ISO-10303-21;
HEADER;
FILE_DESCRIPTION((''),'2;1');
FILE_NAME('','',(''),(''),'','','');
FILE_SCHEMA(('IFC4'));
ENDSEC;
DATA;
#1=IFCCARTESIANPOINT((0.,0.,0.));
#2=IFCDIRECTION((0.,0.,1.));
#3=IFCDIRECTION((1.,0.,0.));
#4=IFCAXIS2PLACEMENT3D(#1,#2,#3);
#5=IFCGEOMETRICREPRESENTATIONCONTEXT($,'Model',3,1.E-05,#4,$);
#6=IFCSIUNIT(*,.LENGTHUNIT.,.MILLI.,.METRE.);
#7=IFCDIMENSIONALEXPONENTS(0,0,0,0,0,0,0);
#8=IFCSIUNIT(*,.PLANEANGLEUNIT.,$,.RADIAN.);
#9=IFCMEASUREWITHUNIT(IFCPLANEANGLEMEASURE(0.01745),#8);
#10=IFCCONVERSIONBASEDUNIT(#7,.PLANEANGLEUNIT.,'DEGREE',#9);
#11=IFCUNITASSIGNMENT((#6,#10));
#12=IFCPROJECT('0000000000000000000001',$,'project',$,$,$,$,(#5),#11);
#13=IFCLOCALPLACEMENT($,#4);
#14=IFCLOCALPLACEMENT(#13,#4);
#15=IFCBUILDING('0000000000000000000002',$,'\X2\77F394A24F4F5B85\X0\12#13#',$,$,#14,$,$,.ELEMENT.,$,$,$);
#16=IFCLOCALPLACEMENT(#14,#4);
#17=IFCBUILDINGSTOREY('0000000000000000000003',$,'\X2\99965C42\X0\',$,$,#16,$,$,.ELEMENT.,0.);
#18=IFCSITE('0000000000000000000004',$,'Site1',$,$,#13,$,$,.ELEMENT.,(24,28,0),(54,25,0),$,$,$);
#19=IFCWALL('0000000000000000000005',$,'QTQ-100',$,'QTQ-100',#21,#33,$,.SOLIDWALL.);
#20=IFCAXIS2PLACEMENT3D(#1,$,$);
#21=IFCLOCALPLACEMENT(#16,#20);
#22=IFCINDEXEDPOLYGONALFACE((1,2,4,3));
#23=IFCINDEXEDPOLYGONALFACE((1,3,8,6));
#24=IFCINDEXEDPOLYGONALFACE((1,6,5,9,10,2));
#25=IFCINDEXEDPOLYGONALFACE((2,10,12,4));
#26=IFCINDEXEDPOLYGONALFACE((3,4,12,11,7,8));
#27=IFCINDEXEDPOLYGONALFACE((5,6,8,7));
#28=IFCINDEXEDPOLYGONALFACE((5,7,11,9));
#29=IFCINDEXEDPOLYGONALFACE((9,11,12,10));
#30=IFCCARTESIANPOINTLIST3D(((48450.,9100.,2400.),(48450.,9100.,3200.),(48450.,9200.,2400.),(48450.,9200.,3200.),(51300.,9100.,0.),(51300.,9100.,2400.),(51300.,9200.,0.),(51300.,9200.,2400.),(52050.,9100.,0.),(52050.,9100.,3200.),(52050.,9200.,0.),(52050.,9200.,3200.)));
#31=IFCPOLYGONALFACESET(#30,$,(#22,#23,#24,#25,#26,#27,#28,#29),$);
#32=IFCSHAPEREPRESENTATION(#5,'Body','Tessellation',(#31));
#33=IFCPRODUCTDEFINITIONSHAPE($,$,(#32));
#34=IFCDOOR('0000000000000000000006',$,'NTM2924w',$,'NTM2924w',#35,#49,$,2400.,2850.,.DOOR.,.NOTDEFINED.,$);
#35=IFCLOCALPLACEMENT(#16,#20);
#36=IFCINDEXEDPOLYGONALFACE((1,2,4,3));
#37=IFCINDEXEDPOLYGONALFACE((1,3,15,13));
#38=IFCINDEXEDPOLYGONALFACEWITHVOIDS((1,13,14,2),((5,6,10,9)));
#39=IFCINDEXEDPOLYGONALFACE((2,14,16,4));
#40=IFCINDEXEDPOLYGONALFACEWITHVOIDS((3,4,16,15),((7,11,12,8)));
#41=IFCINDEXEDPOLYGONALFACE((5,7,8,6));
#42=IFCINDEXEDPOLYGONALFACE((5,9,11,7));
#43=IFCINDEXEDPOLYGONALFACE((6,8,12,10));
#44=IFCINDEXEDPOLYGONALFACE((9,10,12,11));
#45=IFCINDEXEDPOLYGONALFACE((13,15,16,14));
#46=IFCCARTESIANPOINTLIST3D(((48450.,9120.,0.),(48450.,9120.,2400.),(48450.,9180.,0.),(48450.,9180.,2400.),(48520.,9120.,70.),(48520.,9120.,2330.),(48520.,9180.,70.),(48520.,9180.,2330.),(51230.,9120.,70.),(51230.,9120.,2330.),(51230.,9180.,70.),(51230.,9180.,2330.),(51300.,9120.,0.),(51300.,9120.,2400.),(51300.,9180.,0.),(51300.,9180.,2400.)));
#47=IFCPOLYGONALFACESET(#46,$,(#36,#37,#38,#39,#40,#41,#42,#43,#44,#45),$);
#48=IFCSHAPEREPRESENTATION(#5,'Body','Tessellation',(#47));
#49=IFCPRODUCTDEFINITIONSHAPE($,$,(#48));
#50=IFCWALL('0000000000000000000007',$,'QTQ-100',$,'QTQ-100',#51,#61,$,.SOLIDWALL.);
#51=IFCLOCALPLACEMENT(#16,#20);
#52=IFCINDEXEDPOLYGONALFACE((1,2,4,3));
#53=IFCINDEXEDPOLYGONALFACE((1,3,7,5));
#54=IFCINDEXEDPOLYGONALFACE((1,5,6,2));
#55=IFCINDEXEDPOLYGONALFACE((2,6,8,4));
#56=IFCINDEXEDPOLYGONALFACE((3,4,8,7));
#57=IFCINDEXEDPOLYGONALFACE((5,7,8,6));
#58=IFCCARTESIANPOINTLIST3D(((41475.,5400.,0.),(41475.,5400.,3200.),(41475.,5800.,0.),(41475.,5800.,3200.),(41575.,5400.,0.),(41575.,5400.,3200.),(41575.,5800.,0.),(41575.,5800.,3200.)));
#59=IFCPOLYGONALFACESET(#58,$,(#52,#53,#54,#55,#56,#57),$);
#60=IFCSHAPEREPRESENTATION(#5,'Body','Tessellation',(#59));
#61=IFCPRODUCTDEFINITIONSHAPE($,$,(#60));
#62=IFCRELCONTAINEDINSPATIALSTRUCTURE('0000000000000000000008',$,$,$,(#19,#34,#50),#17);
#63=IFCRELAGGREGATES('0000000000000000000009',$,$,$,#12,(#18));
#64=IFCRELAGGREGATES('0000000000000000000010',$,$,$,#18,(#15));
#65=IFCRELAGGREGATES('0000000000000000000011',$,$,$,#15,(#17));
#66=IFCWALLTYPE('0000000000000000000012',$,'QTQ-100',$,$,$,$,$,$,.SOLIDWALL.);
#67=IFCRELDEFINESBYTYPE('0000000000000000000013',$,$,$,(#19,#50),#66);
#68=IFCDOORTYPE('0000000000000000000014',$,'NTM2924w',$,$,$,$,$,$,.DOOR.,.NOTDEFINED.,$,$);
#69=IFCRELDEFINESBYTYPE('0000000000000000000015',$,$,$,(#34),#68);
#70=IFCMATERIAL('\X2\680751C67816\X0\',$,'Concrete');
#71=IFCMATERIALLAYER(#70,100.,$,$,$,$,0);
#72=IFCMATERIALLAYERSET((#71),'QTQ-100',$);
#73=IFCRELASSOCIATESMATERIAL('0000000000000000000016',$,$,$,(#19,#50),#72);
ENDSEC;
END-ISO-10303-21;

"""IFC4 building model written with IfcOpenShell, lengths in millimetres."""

from ifc_helpers import new_model, entity, si_unit, converted_unit, frame, origin_with_axes, place, context, project, spatial, polyline, outline, extrude, material, layer, layer_set, type_object, element, fill, save


model = new_model("IFC4")

# Units and contexts
model_context = context("Model", 3, precision=1e-05, world=origin_with_axes())
ifc_project = project(units=[si_unit("LENGTHUNIT", "METRE", prefix="MILLI"), converted_unit("PLANEANGLEUNIT", "DEGREE", entity("IfcPlaneAngleMeasure", 0.01745), si_unit("PLANEANGLEUNIT", "RADIAN"), dimensions=[0, 0, 0, 0, 0, 0, 0])], contexts=[model_context])

# Site, building, storey
site_placement = place(None, origin_with_axes())
site = spatial("IfcSite", under=ifc_project, at=site_placement, Name="Site1", CompositionType="ELEMENT", RefLatitude=(24, 28, 0), RefLongitude=(54, 25, 0))
building_placement = place(site_placement, origin_with_axes())
building = spatial("IfcBuilding", under=site, at=building_placement, Name="石钢住宅12#13#", CompositionType="ELEMENT")
storey_placement = place(building_placement, origin_with_axes())
storey = spatial("IfcBuildingStorey", under=building, at=storey_placement, Name="首层", CompositionType="ELEMENT", Elevation=0.0)

# Shared definitions
ifc_material = material(Name="标准砖", Category="Concrete")
ifc_layer = layer(ifc_material, 100.0, Priority=0)
ifc_layer_set = layer_set([ifc_layer], Name="QTQ-100")
wall_type = type_object("IfcWallType", Name="QTQ-100", PredefinedType="SOLIDWALL")

# Wall, opening, door
wall_1_placement = place(storey_placement, origin_with_axes())
wall_1 = element("IfcWall", 1, at=wall_1_placement, inside=storey, type_object=wall_type, material=ifc_layer_set, Name="QTQ-100", ObjectType="QTQ-100", PredefinedType="SOLIDWALL", context=model_context, shape_type="SweptSolid", body=[
    extrude(outline(polyline([(0.0, 0.0), (3200.0, 0.0), (3200.0, 3600.0), (0.0, 3600.0), (0.0, 0.0)])), frame((52050.0, 9100.0, 3200.0), z_axis=(0.0, 1.0, 0.0), x_axis=(0.0, 0.0, -1.0)), (0.0, 0.0, 1.0), 100.0),
])
opening_1_placement = place(storey_placement, origin_with_axes())
opening_1 = element("IfcOpeningElement", 2, at=opening_1_placement, cuts=wall_1, PredefinedType="OPENING", context=model_context, shape_type="SweptSolid", body=[
    extrude(outline(polyline([(0.0, 0.0), (2850.0, 0.0), (2850.0, 2400.0), (0.0, 2400.0), (0.0, 0.0)])), frame((51300.0, 8100.0, 0.0), z_axis=(0.0, 1.0, 0.0), x_axis=(-1.0, 0.0, 0.0)), (0.0, 0.0, 1.0), 2100.0),
])
door_type_1 = type_object("IfcDoorType", Name="NTM2924w", OperationType="NOTDEFINED", PredefinedType="DOOR")
door_1_placement = place(storey_placement, origin_with_axes())
door_1 = element("IfcDoor", 3, at=door_1_placement, inside=storey, type_object=door_type_1, Name="NTM2924w", ObjectType="NTM2924w", OperationType="NOTDEFINED", OverallHeight=2400.0, OverallWidth=2850.0, PredefinedType="DOOR", context=model_context, shape_type="SweptSolid", body=[
    extrude(outline(polyline([(-1425.0, -1200.0), (1425.0, -1200.0), (1425.0, 1200.0), (-1425.0, 1200.0), (-1425.0, -1200.0)]), holes=[polyline([(-1355.0, -1130.0), (-1355.0, 1130.0), (1355.0, 1130.0), (1355.0, -1130.0), (-1355.0, -1130.0)])]), frame((49875.0, 9120.0, 1200.0), z_axis=(0.0, 1.0, 0.0), x_axis=(-1.0, 0.0, 0.0)), (0.0, 0.0, 1.0), 60.0),
])
fill(opening_1, door_1)

# Wall
wall_2_placement = place(storey_placement, origin_with_axes())
element("IfcWall", 4, at=wall_2_placement, inside=storey, type_object=wall_type, material=ifc_layer_set, Name="QTQ-100", ObjectType="QTQ-100", PredefinedType="SOLIDWALL", context=model_context, shape_type="SweptSolid", body=[
    extrude(outline(polyline([(0.0, 0.0), (3200.0, 0.0), (3200.0, 400.0), (0.0, 400.0), (0.0, 0.0)])), frame((41575.0, 5800.0, 3200.0), z_axis=(-1.0, 0.0, 0.0), x_axis=(0.0, 0.0, -1.0)), (0.0, 0.0, 1.0), 100.0),
])

save(model, "model.ifc")
